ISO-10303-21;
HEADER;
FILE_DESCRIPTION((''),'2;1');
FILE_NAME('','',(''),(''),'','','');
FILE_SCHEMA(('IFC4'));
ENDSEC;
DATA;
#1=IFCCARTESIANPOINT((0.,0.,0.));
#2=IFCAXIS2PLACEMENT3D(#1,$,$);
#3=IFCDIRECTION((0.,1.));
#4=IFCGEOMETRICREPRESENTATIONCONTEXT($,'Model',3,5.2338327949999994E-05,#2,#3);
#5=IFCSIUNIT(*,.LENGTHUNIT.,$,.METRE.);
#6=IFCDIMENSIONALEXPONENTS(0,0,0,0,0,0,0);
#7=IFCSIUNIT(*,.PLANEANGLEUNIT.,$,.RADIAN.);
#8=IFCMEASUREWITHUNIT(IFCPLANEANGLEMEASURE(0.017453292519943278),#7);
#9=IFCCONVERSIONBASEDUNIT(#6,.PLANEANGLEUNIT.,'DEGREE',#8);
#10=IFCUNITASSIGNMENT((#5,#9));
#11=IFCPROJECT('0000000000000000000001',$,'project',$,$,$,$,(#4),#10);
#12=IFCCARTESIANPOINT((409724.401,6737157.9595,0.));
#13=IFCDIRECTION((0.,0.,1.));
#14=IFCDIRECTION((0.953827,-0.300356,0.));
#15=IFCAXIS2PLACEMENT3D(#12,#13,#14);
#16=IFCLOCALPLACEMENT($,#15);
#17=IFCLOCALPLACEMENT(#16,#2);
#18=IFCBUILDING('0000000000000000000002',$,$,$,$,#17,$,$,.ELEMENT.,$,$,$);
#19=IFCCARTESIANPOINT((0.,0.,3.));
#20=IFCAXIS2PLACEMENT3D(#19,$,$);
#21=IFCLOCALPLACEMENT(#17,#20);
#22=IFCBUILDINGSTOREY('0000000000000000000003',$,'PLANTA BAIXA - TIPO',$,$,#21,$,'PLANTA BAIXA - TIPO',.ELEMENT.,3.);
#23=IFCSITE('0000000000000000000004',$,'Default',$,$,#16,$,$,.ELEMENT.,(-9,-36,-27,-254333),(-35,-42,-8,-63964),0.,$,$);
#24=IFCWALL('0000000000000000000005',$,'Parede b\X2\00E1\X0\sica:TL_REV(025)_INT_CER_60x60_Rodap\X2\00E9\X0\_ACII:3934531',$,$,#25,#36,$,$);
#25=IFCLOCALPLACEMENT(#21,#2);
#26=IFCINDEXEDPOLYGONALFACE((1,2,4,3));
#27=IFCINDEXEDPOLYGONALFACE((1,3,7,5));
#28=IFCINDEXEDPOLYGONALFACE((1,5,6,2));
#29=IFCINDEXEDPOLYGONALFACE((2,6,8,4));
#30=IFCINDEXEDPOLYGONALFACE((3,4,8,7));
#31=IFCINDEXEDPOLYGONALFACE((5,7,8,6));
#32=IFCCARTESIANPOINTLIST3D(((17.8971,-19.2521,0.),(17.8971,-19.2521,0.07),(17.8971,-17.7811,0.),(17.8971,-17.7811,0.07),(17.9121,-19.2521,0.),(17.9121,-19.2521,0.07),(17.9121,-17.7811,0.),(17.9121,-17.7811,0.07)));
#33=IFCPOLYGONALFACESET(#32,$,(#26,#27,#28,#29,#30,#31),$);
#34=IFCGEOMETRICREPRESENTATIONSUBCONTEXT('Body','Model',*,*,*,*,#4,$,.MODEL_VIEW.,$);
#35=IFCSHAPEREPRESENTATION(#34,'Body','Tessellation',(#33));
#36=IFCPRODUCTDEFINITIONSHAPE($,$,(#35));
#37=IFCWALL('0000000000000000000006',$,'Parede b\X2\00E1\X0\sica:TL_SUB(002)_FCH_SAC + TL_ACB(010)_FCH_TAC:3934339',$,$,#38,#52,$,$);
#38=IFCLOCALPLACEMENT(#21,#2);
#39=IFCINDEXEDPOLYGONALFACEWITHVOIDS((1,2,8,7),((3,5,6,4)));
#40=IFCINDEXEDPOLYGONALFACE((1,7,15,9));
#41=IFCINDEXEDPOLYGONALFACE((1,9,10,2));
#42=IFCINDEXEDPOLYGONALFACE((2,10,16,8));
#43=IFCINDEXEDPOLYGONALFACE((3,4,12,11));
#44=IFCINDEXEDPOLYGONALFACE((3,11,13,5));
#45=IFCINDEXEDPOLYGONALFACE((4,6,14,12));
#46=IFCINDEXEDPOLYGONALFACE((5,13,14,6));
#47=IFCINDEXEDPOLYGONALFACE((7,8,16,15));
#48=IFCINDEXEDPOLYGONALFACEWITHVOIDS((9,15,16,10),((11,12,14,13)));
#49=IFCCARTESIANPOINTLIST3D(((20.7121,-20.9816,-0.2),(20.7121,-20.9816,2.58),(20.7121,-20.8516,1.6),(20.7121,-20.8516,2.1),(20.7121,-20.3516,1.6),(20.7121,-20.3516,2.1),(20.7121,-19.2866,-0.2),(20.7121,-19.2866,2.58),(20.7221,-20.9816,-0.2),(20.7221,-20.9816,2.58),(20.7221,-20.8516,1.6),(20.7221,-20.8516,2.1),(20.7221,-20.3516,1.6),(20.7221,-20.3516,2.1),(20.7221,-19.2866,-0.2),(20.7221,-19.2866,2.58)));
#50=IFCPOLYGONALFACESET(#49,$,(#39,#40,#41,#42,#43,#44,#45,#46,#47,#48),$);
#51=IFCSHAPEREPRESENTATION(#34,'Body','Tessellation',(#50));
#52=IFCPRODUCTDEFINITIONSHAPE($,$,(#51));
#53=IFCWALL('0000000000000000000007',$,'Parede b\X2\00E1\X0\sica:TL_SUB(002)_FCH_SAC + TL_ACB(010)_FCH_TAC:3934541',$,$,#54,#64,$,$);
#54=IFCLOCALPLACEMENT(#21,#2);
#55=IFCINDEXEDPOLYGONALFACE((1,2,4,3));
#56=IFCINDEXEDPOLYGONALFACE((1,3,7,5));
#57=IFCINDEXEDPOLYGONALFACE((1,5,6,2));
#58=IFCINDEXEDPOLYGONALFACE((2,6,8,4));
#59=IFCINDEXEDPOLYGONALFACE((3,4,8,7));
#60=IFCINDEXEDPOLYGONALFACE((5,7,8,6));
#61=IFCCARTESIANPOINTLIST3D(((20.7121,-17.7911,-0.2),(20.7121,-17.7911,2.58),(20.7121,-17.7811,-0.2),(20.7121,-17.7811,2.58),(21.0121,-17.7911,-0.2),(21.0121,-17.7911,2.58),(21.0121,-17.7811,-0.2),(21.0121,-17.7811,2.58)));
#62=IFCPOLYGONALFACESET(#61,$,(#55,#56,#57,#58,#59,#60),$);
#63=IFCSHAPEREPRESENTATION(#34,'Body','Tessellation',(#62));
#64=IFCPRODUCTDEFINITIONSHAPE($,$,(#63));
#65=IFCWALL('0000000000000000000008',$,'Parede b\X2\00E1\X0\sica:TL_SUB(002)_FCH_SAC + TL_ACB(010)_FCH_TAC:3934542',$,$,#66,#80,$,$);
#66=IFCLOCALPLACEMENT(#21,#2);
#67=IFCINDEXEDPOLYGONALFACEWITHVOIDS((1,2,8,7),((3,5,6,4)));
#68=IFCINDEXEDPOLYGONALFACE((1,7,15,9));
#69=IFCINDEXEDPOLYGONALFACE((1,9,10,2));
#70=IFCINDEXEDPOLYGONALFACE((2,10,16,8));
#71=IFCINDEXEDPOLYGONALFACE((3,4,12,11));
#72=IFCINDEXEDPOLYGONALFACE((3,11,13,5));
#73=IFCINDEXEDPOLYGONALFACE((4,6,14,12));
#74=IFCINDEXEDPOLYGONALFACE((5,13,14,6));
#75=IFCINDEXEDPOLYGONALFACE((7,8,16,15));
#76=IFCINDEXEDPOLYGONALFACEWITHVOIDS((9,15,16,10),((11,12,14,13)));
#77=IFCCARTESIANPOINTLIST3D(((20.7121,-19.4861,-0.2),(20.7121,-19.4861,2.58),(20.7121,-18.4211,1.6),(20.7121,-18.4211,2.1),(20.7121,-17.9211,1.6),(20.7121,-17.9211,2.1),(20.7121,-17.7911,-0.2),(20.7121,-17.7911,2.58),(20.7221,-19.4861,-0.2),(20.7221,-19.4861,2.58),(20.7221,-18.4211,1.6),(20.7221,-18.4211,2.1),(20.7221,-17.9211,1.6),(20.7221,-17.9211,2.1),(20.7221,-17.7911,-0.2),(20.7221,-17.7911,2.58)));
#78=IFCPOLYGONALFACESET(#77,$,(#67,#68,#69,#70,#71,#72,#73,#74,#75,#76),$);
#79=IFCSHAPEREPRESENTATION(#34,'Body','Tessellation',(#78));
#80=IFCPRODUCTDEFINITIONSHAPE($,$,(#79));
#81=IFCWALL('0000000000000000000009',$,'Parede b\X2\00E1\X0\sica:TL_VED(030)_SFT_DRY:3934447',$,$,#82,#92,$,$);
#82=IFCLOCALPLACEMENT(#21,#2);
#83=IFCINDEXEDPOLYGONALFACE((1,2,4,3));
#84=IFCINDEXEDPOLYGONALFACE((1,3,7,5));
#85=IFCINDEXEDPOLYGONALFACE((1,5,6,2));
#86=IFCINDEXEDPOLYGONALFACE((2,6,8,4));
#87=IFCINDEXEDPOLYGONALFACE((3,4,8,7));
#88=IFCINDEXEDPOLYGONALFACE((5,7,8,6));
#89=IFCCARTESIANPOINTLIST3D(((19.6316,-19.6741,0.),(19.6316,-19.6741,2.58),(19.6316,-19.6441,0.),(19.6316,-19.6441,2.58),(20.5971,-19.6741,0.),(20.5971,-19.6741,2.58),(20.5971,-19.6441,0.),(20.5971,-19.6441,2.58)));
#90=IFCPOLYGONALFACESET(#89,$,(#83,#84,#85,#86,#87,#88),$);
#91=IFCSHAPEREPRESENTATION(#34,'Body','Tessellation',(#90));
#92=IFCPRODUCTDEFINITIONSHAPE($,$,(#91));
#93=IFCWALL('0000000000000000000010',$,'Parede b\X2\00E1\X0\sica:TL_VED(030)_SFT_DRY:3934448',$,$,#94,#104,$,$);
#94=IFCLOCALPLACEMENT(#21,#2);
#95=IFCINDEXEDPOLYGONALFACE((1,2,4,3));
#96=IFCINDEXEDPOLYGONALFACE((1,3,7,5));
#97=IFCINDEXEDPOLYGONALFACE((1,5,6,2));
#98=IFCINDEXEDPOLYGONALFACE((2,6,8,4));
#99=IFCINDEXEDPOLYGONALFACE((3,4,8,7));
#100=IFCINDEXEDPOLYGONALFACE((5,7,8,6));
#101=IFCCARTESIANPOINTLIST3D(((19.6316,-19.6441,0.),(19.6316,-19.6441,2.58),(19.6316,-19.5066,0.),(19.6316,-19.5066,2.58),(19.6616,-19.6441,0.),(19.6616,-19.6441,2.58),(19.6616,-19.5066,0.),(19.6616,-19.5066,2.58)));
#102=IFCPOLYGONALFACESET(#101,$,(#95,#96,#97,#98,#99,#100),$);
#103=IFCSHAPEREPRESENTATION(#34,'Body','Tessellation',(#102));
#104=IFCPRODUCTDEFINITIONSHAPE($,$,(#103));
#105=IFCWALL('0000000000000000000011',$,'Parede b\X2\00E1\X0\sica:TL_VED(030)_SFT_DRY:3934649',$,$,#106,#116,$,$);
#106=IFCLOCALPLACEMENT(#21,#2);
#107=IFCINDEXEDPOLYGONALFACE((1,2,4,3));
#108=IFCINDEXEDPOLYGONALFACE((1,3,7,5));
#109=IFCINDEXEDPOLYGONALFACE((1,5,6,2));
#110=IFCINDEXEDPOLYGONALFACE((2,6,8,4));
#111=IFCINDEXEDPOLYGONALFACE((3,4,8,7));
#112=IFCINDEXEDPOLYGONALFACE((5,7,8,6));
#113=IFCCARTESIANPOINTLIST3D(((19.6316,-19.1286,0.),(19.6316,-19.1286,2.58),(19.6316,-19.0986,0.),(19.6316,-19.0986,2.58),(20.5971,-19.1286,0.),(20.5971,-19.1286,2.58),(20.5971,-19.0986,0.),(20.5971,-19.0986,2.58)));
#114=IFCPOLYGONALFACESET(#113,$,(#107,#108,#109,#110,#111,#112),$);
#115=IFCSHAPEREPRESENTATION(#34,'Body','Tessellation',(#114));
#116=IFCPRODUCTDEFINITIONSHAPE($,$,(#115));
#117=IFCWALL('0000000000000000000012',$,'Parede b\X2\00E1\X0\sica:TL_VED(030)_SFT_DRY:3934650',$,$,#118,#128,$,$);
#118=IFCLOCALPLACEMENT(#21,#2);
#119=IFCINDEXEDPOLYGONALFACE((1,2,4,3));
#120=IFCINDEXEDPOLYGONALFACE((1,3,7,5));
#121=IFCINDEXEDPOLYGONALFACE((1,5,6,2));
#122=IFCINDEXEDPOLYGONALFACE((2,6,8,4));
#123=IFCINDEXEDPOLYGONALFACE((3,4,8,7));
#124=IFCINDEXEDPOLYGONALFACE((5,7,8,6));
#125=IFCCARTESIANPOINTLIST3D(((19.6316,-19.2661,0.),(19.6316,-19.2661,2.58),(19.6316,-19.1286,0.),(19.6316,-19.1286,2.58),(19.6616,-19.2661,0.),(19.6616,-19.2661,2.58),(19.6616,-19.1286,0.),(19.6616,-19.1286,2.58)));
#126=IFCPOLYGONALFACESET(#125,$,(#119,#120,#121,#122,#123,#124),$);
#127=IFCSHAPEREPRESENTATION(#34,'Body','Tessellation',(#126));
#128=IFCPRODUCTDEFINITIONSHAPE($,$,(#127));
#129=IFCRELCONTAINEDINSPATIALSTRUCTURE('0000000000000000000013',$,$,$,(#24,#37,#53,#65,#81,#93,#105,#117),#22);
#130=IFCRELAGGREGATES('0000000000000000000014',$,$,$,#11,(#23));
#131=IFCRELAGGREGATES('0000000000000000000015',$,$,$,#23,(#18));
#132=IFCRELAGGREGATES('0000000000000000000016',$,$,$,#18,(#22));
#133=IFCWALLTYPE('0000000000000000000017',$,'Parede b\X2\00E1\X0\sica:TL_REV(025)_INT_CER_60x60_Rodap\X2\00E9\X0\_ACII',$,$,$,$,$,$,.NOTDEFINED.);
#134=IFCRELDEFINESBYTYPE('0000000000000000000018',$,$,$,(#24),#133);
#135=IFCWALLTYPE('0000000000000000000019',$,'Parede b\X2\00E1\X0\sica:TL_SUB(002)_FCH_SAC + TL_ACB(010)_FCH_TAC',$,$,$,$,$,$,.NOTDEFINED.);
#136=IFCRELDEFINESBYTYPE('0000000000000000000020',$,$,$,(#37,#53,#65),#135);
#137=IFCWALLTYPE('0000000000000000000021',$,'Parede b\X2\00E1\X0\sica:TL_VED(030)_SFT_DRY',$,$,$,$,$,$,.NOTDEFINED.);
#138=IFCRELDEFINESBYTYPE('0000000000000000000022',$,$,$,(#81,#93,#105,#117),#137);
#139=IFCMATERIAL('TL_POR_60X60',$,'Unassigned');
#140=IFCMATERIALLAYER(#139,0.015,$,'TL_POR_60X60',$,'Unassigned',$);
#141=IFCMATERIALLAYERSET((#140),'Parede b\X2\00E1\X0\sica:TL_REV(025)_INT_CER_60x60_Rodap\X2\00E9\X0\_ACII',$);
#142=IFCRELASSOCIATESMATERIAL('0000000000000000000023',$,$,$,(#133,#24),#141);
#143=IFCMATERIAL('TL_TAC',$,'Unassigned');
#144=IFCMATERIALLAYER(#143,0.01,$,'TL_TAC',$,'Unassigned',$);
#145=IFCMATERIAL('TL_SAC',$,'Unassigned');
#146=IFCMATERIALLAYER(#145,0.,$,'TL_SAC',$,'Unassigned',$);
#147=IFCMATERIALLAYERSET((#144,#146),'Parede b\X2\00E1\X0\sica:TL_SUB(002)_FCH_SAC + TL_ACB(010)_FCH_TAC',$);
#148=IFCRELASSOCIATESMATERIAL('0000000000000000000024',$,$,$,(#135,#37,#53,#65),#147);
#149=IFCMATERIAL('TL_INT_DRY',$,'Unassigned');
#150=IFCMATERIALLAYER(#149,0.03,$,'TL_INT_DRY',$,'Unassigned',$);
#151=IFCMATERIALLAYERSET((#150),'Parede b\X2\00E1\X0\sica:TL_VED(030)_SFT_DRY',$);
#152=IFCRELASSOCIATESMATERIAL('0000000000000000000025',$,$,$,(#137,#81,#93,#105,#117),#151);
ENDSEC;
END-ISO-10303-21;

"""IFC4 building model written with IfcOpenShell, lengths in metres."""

from ifc_helpers import new_model, entity, si_unit, converted_unit, direction, frame, frame_2d, origin, place, context, subcontext, project, spatial, rectangle, extrude, material, layer, layer_set, layer_usage, type_object, element, save


model = new_model("IFC4")

# Units and contexts
model_context = context("Model", 3, precision=5.2338327949999994e-05, world=origin(), true_north=direction((0.0, 1.0)))
body_context = subcontext(model_context, "Body", "Model", "MODEL_VIEW")
ifc_project = project(units=[si_unit("LENGTHUNIT", "METRE"), converted_unit("PLANEANGLEUNIT", "DEGREE", entity("IfcPlaneAngleMeasure", 0.017453292519943278), si_unit("PLANEANGLEUNIT", "RADIAN"), dimensions=[0, 0, 0, 0, 0, 0, 0])], contexts=[model_context])

# Site, building, storey
site_placement = place(None, frame((409724.401, 6737157.9595, 0.0), z_axis=(0.0, 0.0, 1.0), x_axis=(0.953827, -0.300356, 0.0)))
site = spatial("IfcSite", under=ifc_project, at=site_placement, Name="Default", CompositionType="ELEMENT", RefLatitude=(-9, -36, -27, -254333), RefLongitude=(-35, -42, -8, -63964), RefElevation=0.0)
building_placement = place(site_placement, origin())
building = spatial("IfcBuilding", under=site, at=building_placement, CompositionType="ELEMENT")
storey_placement = place(building_placement, frame((0.0, 0.0, 3.0)))
storey = spatial("IfcBuildingStorey", under=building, at=storey_placement, Name="PLANTA BAIXA - TIPO", LongName="PLANTA BAIXA - TIPO", CompositionType="ELEMENT", Elevation=3.0)

# Shared definitions
ifc_material_1 = material(Name="TL_SAC", Category="Unassigned")

# Shared definitions
ifc_material_2 = material(Name="TL_POR_60X60", Category="Unassigned")

# Wall
ifc_layer_1 = layer(ifc_material_2, 0.015, Name="TL_POR_60X60", Category="Unassigned")
ifc_layer_set_1 = layer_set([ifc_layer_1], Name="Parede básica:TL_REV(025)_INT_CER_60x60_Rodapé_ACII")
ifc_layer_usage_1 = layer_usage(ifc_layer_set_1, "AXIS2", "NEGATIVE", 0.0075)
wall_type_1 = type_object("IfcWallType", Name="Parede básica:TL_REV(025)_INT_CER_60x60_Rodapé_ACII", PredefinedType="NOTDEFINED", material=ifc_layer_set_1)
wall_1_placement = place(storey_placement, frame((17.9046, -19.2521, 0.0), z_axis=(0.0, 0.0, 1.0), x_axis=(0.0, 1.0, 0.0)))
element("IfcWall", 1, at=wall_1_placement, inside=storey, type_object=wall_type_1, material=ifc_layer_usage_1, Name="Parede básica:TL_REV(025)_INT_CER_60x60_Rodapé_ACII:3934531", context=body_context, shape_type="SweptSolid", body=[
    extrude(rectangle(XDim=1.471, YDim=0.015, at=frame_2d((0.7355, 0.0), x_axis=(-1.0, 0.0))), origin(), (0.0, 0.0, 1.0), 0.07),
])

# Wall, opening
ifc_material_3 = material(Name="TL_TAC", Category="Unassigned")
ifc_layer_2 = layer(ifc_material_3, 0.01, Name="TL_TAC", Category="Unassigned")
ifc_layer_3 = layer(ifc_material_1, 0.0, Name="TL_SAC", Category="Unassigned")
ifc_layer_set_2 = layer_set([ifc_layer_2, ifc_layer_3], Name="Parede básica:TL_SUB(002)_FCH_SAC + TL_ACB(010)_FCH_TAC")
ifc_layer_usage_2 = layer_usage(ifc_layer_set_2, "AXIS2", "NEGATIVE", 0.005)
wall_type_2 = type_object("IfcWallType", Name="Parede básica:TL_SUB(002)_FCH_SAC + TL_ACB(010)_FCH_TAC", PredefinedType="NOTDEFINED", material=ifc_layer_set_2)
wall_2_placement = place(storey_placement, frame((20.7171, -20.9816, -0.2), z_axis=(0.0, 0.0, 1.0), x_axis=(0.0, 1.0, 0.0)))
wall_2 = element("IfcWall", 2, at=wall_2_placement, inside=storey, type_object=wall_type_2, material=ifc_layer_usage_2, Name="Parede básica:TL_SUB(002)_FCH_SAC + TL_ACB(010)_FCH_TAC:3934339", context=body_context, shape_type="SweptSolid", body=[
    extrude(rectangle(XDim=1.695, YDim=0.01, at=frame_2d((0.8475, 0.0), x_axis=(-1.0, 0.0))), origin(), (0.0, 0.0, 1.0), 2.78),
])
opening_1_placement = place(wall_2_placement, frame((20.9816, 20.7171, 1.8)))
element("IfcOpeningElement", 3, at=opening_1_placement, cuts=wall_2, PredefinedType="OPENING", context=body_context, shape_type="SweptSolid", body=[
    extrude(rectangle(XDim=0.5, YDim=0.5, at=frame_2d((0.0, 0.0), x_axis=(1.0, 0.0))), frame((-20.6016, -22.2361, 0.25), z_axis=(0.0, 1.0, 0.0), x_axis=(0.0, 0.0, 1.0)), (0.0, 0.0, 1.0), 3.048),
])

# Wall
ifc_layer_usage_3 = layer_usage(ifc_layer_set_2, "AXIS2", "POSITIVE", -0.005)
wall_3_placement = place(storey_placement, frame((21.0121, -17.7861, -0.2), z_axis=(0.0, 0.0, 1.0), x_axis=(-1.0, 0.0, 0.0)))
element("IfcWall", 4, at=wall_3_placement, inside=storey, type_object=wall_type_2, material=ifc_layer_usage_3, Name="Parede básica:TL_SUB(002)_FCH_SAC + TL_ACB(010)_FCH_TAC:3934541", context=body_context, shape_type="SweptSolid", body=[
    extrude(rectangle(XDim=0.3, YDim=0.01, at=frame_2d((0.15, 0.0), x_axis=(-1.0, 0.0))), origin(), (0.0, 0.0, 1.0), 2.78),
])

# Wall, opening
ifc_layer_usage_4 = layer_usage(ifc_layer_set_2, "AXIS2", "POSITIVE", -0.005)
wall_4_placement = place(storey_placement, frame((20.7171, -17.7911, -0.2), z_axis=(0.0, 0.0, 1.0), x_axis=(0.0, -1.0, 0.0)))
wall_4 = element("IfcWall", 5, at=wall_4_placement, inside=storey, type_object=wall_type_2, material=ifc_layer_usage_4, Name="Parede básica:TL_SUB(002)_FCH_SAC + TL_ACB(010)_FCH_TAC:3934542", context=body_context, shape_type="SweptSolid", body=[
    extrude(rectangle(XDim=1.695, YDim=0.01, at=frame_2d((0.8475, 0.0), x_axis=(-1.0, 0.0))), origin(), (0.0, 0.0, 1.0), 2.78),
])
opening_2_placement = place(wall_4_placement, frame((-17.7911, -20.7171, 1.8)))
element("IfcOpeningElement", 6, at=opening_2_placement, cuts=wall_4, PredefinedType="OPENING", context=body_context, shape_type="SweptSolid", body=[
    extrude(rectangle(XDim=0.5, YDim=0.5, at=frame_2d((0.0, 0.0), x_axis=(1.0, 0.0))), frame((18.1711, 19.1881, 0.25), z_axis=(0.0, 1.0, 0.0), x_axis=(0.0, 0.0, 1.0)), (0.0, 0.0, 1.0), 3.048),
])

# Walls
ifc_material_4 = material(Name="TL_INT_DRY", Category="Unassigned")
ifc_layer_4 = layer(ifc_material_4, 0.03, Name="TL_INT_DRY", Category="Unassigned")
ifc_layer_set_3 = layer_set([ifc_layer_4], Name="Parede básica:TL_VED(030)_SFT_DRY")
ifc_layer_usage_5 = layer_usage(ifc_layer_set_3, "AXIS2", "NEGATIVE", 0.015)
wall_type_3 = type_object("IfcWallType", Name="Parede básica:TL_VED(030)_SFT_DRY", PredefinedType="NOTDEFINED", material=ifc_layer_set_3)
wall_5_placement = place(storey_placement, frame((20.5971, -19.6591, 0.0), z_axis=(0.0, 0.0, 1.0), x_axis=(-1.0, 0.0, 0.0)))
element("IfcWall", 7, at=wall_5_placement, inside=storey, type_object=wall_type_3, material=ifc_layer_usage_5, Name="Parede básica:TL_VED(030)_SFT_DRY:3934447", context=body_context, shape_type="SweptSolid", body=[
    extrude(rectangle(XDim=0.9655, YDim=0.03, at=frame_2d((0.4828, 0.0), x_axis=(-1.0, 0.0))), origin(), (0.0, 0.0, 1.0), 2.58),
])
ifc_layer_usage_6 = layer_usage(ifc_layer_set_3, "AXIS2", "NEGATIVE", 0.015)
wall_6_placement = place(storey_placement, frame((19.6466, -19.6441, 0.0), z_axis=(0.0, 0.0, 1.0), x_axis=(0.0, 1.0, 0.0)))
element("IfcWall", 8, at=wall_6_placement, inside=storey, type_object=wall_type_3, material=ifc_layer_usage_6, Name="Parede básica:TL_VED(030)_SFT_DRY:3934448", context=body_context, shape_type="SweptSolid", body=[
    extrude(rectangle(XDim=0.1375, YDim=0.03, at=frame_2d((0.0688, 0.0), x_axis=(-1.0, 0.0))), origin(), (0.0, 0.0, 1.0), 2.58),
])
ifc_layer_usage_7 = layer_usage(ifc_layer_set_3, "AXIS2", "POSITIVE", -0.015)
wall_7_placement = place(storey_placement, frame((20.5971, -19.1136, 0.0), z_axis=(0.0, 0.0, 1.0), x_axis=(-1.0, 0.0, 0.0)))
element("IfcWall", 9, at=wall_7_placement, inside=storey, type_object=wall_type_3, material=ifc_layer_usage_7, Name="Parede básica:TL_VED(030)_SFT_DRY:3934649", context=body_context, shape_type="SweptSolid", body=[
    extrude(rectangle(XDim=0.9655, YDim=0.03, at=frame_2d((0.4828, 0.0), x_axis=(-1.0, 0.0))), origin(), (0.0, 0.0, 1.0), 2.58),
])
ifc_layer_usage_8 = layer_usage(ifc_layer_set_3, "AXIS2", "POSITIVE", -0.015)
wall_8_placement = place(storey_placement, frame((19.6466, -19.1286, 0.0), z_axis=(0.0, 0.0, 1.0), x_axis=(0.0, -1.0, 0.0)))
element("IfcWall", 10, at=wall_8_placement, inside=storey, type_object=wall_type_3, material=ifc_layer_usage_8, Name="Parede básica:TL_VED(030)_SFT_DRY:3934650", context=body_context, shape_type="SweptSolid", body=[
    extrude(rectangle(XDim=0.1375, YDim=0.03, at=frame_2d((0.0688, 0.0), x_axis=(-1.0, 0.0))), origin(), (0.0, 0.0, 1.0), 2.58),
])

save(model, "model.ifc")
